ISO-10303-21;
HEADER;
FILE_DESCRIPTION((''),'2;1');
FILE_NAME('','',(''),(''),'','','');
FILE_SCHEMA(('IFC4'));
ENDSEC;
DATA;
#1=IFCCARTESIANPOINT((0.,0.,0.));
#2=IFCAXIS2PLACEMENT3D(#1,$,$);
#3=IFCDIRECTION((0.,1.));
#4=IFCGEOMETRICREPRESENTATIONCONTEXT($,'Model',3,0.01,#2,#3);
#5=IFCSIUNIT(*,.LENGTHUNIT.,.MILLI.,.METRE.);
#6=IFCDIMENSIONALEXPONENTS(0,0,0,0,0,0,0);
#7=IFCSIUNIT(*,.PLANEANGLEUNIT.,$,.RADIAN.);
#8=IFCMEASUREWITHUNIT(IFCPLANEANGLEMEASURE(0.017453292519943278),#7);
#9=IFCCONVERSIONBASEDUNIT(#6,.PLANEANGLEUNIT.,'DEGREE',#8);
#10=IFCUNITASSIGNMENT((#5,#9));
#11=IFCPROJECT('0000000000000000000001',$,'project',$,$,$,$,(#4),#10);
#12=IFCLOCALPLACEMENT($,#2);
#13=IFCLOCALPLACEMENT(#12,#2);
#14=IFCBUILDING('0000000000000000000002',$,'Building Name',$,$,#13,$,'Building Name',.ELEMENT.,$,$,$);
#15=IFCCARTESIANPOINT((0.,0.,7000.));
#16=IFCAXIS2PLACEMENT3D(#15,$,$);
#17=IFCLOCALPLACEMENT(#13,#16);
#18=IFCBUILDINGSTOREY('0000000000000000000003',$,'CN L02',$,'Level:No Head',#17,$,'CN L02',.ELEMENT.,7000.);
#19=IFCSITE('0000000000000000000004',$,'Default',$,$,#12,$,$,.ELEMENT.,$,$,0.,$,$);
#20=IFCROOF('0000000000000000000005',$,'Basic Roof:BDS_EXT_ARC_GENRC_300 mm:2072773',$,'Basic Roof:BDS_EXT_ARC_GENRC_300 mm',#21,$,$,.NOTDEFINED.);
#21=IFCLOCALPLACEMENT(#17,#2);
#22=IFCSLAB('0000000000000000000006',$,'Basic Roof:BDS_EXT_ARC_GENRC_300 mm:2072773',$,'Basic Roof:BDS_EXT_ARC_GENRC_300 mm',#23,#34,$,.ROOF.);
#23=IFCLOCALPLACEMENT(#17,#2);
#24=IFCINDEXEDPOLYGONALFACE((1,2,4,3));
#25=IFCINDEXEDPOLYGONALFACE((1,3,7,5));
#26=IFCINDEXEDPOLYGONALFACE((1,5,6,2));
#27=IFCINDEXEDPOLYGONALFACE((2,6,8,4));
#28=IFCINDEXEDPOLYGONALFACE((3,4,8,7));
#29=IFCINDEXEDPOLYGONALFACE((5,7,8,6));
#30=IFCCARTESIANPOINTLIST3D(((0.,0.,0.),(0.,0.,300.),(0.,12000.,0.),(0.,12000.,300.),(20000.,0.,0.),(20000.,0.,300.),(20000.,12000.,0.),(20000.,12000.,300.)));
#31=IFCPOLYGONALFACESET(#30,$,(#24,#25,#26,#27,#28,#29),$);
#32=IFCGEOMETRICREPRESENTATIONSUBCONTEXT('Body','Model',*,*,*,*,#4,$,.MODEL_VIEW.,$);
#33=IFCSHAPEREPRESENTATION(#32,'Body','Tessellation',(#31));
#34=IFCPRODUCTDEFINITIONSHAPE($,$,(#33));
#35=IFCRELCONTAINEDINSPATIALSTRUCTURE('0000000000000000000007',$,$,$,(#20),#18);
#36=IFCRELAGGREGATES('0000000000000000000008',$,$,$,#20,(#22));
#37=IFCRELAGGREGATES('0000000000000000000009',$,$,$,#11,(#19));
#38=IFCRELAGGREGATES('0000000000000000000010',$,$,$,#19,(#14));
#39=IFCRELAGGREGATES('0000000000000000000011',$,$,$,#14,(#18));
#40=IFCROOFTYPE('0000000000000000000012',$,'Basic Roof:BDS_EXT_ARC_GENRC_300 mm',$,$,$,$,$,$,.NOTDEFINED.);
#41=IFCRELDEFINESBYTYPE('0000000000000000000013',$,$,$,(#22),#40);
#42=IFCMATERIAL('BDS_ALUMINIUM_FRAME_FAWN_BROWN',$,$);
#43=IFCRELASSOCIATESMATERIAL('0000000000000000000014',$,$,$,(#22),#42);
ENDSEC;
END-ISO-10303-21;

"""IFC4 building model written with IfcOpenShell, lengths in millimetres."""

from ifc_helpers import new_model, entity, si_unit, converted_unit, direction, frame, origin, place, context, subcontext, project, spatial, indexed_curve, outline, extrude, material, type_object, element, aggregate, save


model = new_model("IFC4")

# Units and contexts
model_context = context("Model", 3, precision=0.01, world=origin(), true_north=direction((0.0, 1.0)))
body_context = subcontext(model_context, "Body", "Model", "MODEL_VIEW")
ifc_project = project(units=[si_unit("LENGTHUNIT", "METRE", prefix="MILLI"), converted_unit("PLANEANGLEUNIT", "DEGREE", entity("IfcPlaneAngleMeasure", 0.017453292519943278), si_unit("PLANEANGLEUNIT", "RADIAN"), dimensions=[0, 0, 0, 0, 0, 0, 0])], contexts=[model_context])

# Site, building, storey
site_placement = place(None, origin())
site = spatial("IfcSite", under=ifc_project, at=site_placement, Name="Default", CompositionType="ELEMENT", RefElevation=0.0)
building_placement = place(site_placement, origin())
building = spatial("IfcBuilding", under=site, at=building_placement, Name="Building Name", LongName="Building Name", CompositionType="ELEMENT")
storey_placement = place(building_placement, frame((0.0, 0.0, 7000.0)))
storey = spatial("IfcBuildingStorey", under=building, at=storey_placement, Name="CN L02", ObjectType="Level:No Head", LongName="CN L02", CompositionType="ELEMENT", Elevation=7000.0)

# Roof, slab
roof_placement = place(storey_placement, origin())
roof = element("IfcRoof", 1, at=roof_placement, inside=storey, Name="Basic Roof:BDS_EXT_ARC_GENRC_300 mm:2072773", ObjectType="Basic Roof:BDS_EXT_ARC_GENRC_300 mm", PredefinedType="NOTDEFINED")
ifc_material = material(Name="BDS_ALUMINIUM_FRAME_FAWN_BROWN")
roof_type = type_object("IfcRoofType", Name="Basic Roof:BDS_EXT_ARC_GENRC_300 mm", PredefinedType="NOTDEFINED")
slab_placement = place(roof_placement, origin())
slab = element("IfcSlab", 2, at=slab_placement, type_object=roof_type, material=ifc_material, Name="Basic Roof:BDS_EXT_ARC_GENRC_300 mm:2072773", ObjectType="Basic Roof:BDS_EXT_ARC_GENRC_300 mm", PredefinedType="ROOF", context=body_context, shape_type="SweptSolid", body=[
    extrude(outline(indexed_curve([(10000.0, -6000.0), (10000.0, 6000.0), (-10000.0, 6000.0), (-10000.0, -6000.0), (10000.0, -6000.0)], self_intersect=False)), frame((10000.0, 6000.0, 0.0)), (0.0, 0.0, 1.0), 300.0),
])
aggregate(roof, [slab])

save(model, "model.ifc")
